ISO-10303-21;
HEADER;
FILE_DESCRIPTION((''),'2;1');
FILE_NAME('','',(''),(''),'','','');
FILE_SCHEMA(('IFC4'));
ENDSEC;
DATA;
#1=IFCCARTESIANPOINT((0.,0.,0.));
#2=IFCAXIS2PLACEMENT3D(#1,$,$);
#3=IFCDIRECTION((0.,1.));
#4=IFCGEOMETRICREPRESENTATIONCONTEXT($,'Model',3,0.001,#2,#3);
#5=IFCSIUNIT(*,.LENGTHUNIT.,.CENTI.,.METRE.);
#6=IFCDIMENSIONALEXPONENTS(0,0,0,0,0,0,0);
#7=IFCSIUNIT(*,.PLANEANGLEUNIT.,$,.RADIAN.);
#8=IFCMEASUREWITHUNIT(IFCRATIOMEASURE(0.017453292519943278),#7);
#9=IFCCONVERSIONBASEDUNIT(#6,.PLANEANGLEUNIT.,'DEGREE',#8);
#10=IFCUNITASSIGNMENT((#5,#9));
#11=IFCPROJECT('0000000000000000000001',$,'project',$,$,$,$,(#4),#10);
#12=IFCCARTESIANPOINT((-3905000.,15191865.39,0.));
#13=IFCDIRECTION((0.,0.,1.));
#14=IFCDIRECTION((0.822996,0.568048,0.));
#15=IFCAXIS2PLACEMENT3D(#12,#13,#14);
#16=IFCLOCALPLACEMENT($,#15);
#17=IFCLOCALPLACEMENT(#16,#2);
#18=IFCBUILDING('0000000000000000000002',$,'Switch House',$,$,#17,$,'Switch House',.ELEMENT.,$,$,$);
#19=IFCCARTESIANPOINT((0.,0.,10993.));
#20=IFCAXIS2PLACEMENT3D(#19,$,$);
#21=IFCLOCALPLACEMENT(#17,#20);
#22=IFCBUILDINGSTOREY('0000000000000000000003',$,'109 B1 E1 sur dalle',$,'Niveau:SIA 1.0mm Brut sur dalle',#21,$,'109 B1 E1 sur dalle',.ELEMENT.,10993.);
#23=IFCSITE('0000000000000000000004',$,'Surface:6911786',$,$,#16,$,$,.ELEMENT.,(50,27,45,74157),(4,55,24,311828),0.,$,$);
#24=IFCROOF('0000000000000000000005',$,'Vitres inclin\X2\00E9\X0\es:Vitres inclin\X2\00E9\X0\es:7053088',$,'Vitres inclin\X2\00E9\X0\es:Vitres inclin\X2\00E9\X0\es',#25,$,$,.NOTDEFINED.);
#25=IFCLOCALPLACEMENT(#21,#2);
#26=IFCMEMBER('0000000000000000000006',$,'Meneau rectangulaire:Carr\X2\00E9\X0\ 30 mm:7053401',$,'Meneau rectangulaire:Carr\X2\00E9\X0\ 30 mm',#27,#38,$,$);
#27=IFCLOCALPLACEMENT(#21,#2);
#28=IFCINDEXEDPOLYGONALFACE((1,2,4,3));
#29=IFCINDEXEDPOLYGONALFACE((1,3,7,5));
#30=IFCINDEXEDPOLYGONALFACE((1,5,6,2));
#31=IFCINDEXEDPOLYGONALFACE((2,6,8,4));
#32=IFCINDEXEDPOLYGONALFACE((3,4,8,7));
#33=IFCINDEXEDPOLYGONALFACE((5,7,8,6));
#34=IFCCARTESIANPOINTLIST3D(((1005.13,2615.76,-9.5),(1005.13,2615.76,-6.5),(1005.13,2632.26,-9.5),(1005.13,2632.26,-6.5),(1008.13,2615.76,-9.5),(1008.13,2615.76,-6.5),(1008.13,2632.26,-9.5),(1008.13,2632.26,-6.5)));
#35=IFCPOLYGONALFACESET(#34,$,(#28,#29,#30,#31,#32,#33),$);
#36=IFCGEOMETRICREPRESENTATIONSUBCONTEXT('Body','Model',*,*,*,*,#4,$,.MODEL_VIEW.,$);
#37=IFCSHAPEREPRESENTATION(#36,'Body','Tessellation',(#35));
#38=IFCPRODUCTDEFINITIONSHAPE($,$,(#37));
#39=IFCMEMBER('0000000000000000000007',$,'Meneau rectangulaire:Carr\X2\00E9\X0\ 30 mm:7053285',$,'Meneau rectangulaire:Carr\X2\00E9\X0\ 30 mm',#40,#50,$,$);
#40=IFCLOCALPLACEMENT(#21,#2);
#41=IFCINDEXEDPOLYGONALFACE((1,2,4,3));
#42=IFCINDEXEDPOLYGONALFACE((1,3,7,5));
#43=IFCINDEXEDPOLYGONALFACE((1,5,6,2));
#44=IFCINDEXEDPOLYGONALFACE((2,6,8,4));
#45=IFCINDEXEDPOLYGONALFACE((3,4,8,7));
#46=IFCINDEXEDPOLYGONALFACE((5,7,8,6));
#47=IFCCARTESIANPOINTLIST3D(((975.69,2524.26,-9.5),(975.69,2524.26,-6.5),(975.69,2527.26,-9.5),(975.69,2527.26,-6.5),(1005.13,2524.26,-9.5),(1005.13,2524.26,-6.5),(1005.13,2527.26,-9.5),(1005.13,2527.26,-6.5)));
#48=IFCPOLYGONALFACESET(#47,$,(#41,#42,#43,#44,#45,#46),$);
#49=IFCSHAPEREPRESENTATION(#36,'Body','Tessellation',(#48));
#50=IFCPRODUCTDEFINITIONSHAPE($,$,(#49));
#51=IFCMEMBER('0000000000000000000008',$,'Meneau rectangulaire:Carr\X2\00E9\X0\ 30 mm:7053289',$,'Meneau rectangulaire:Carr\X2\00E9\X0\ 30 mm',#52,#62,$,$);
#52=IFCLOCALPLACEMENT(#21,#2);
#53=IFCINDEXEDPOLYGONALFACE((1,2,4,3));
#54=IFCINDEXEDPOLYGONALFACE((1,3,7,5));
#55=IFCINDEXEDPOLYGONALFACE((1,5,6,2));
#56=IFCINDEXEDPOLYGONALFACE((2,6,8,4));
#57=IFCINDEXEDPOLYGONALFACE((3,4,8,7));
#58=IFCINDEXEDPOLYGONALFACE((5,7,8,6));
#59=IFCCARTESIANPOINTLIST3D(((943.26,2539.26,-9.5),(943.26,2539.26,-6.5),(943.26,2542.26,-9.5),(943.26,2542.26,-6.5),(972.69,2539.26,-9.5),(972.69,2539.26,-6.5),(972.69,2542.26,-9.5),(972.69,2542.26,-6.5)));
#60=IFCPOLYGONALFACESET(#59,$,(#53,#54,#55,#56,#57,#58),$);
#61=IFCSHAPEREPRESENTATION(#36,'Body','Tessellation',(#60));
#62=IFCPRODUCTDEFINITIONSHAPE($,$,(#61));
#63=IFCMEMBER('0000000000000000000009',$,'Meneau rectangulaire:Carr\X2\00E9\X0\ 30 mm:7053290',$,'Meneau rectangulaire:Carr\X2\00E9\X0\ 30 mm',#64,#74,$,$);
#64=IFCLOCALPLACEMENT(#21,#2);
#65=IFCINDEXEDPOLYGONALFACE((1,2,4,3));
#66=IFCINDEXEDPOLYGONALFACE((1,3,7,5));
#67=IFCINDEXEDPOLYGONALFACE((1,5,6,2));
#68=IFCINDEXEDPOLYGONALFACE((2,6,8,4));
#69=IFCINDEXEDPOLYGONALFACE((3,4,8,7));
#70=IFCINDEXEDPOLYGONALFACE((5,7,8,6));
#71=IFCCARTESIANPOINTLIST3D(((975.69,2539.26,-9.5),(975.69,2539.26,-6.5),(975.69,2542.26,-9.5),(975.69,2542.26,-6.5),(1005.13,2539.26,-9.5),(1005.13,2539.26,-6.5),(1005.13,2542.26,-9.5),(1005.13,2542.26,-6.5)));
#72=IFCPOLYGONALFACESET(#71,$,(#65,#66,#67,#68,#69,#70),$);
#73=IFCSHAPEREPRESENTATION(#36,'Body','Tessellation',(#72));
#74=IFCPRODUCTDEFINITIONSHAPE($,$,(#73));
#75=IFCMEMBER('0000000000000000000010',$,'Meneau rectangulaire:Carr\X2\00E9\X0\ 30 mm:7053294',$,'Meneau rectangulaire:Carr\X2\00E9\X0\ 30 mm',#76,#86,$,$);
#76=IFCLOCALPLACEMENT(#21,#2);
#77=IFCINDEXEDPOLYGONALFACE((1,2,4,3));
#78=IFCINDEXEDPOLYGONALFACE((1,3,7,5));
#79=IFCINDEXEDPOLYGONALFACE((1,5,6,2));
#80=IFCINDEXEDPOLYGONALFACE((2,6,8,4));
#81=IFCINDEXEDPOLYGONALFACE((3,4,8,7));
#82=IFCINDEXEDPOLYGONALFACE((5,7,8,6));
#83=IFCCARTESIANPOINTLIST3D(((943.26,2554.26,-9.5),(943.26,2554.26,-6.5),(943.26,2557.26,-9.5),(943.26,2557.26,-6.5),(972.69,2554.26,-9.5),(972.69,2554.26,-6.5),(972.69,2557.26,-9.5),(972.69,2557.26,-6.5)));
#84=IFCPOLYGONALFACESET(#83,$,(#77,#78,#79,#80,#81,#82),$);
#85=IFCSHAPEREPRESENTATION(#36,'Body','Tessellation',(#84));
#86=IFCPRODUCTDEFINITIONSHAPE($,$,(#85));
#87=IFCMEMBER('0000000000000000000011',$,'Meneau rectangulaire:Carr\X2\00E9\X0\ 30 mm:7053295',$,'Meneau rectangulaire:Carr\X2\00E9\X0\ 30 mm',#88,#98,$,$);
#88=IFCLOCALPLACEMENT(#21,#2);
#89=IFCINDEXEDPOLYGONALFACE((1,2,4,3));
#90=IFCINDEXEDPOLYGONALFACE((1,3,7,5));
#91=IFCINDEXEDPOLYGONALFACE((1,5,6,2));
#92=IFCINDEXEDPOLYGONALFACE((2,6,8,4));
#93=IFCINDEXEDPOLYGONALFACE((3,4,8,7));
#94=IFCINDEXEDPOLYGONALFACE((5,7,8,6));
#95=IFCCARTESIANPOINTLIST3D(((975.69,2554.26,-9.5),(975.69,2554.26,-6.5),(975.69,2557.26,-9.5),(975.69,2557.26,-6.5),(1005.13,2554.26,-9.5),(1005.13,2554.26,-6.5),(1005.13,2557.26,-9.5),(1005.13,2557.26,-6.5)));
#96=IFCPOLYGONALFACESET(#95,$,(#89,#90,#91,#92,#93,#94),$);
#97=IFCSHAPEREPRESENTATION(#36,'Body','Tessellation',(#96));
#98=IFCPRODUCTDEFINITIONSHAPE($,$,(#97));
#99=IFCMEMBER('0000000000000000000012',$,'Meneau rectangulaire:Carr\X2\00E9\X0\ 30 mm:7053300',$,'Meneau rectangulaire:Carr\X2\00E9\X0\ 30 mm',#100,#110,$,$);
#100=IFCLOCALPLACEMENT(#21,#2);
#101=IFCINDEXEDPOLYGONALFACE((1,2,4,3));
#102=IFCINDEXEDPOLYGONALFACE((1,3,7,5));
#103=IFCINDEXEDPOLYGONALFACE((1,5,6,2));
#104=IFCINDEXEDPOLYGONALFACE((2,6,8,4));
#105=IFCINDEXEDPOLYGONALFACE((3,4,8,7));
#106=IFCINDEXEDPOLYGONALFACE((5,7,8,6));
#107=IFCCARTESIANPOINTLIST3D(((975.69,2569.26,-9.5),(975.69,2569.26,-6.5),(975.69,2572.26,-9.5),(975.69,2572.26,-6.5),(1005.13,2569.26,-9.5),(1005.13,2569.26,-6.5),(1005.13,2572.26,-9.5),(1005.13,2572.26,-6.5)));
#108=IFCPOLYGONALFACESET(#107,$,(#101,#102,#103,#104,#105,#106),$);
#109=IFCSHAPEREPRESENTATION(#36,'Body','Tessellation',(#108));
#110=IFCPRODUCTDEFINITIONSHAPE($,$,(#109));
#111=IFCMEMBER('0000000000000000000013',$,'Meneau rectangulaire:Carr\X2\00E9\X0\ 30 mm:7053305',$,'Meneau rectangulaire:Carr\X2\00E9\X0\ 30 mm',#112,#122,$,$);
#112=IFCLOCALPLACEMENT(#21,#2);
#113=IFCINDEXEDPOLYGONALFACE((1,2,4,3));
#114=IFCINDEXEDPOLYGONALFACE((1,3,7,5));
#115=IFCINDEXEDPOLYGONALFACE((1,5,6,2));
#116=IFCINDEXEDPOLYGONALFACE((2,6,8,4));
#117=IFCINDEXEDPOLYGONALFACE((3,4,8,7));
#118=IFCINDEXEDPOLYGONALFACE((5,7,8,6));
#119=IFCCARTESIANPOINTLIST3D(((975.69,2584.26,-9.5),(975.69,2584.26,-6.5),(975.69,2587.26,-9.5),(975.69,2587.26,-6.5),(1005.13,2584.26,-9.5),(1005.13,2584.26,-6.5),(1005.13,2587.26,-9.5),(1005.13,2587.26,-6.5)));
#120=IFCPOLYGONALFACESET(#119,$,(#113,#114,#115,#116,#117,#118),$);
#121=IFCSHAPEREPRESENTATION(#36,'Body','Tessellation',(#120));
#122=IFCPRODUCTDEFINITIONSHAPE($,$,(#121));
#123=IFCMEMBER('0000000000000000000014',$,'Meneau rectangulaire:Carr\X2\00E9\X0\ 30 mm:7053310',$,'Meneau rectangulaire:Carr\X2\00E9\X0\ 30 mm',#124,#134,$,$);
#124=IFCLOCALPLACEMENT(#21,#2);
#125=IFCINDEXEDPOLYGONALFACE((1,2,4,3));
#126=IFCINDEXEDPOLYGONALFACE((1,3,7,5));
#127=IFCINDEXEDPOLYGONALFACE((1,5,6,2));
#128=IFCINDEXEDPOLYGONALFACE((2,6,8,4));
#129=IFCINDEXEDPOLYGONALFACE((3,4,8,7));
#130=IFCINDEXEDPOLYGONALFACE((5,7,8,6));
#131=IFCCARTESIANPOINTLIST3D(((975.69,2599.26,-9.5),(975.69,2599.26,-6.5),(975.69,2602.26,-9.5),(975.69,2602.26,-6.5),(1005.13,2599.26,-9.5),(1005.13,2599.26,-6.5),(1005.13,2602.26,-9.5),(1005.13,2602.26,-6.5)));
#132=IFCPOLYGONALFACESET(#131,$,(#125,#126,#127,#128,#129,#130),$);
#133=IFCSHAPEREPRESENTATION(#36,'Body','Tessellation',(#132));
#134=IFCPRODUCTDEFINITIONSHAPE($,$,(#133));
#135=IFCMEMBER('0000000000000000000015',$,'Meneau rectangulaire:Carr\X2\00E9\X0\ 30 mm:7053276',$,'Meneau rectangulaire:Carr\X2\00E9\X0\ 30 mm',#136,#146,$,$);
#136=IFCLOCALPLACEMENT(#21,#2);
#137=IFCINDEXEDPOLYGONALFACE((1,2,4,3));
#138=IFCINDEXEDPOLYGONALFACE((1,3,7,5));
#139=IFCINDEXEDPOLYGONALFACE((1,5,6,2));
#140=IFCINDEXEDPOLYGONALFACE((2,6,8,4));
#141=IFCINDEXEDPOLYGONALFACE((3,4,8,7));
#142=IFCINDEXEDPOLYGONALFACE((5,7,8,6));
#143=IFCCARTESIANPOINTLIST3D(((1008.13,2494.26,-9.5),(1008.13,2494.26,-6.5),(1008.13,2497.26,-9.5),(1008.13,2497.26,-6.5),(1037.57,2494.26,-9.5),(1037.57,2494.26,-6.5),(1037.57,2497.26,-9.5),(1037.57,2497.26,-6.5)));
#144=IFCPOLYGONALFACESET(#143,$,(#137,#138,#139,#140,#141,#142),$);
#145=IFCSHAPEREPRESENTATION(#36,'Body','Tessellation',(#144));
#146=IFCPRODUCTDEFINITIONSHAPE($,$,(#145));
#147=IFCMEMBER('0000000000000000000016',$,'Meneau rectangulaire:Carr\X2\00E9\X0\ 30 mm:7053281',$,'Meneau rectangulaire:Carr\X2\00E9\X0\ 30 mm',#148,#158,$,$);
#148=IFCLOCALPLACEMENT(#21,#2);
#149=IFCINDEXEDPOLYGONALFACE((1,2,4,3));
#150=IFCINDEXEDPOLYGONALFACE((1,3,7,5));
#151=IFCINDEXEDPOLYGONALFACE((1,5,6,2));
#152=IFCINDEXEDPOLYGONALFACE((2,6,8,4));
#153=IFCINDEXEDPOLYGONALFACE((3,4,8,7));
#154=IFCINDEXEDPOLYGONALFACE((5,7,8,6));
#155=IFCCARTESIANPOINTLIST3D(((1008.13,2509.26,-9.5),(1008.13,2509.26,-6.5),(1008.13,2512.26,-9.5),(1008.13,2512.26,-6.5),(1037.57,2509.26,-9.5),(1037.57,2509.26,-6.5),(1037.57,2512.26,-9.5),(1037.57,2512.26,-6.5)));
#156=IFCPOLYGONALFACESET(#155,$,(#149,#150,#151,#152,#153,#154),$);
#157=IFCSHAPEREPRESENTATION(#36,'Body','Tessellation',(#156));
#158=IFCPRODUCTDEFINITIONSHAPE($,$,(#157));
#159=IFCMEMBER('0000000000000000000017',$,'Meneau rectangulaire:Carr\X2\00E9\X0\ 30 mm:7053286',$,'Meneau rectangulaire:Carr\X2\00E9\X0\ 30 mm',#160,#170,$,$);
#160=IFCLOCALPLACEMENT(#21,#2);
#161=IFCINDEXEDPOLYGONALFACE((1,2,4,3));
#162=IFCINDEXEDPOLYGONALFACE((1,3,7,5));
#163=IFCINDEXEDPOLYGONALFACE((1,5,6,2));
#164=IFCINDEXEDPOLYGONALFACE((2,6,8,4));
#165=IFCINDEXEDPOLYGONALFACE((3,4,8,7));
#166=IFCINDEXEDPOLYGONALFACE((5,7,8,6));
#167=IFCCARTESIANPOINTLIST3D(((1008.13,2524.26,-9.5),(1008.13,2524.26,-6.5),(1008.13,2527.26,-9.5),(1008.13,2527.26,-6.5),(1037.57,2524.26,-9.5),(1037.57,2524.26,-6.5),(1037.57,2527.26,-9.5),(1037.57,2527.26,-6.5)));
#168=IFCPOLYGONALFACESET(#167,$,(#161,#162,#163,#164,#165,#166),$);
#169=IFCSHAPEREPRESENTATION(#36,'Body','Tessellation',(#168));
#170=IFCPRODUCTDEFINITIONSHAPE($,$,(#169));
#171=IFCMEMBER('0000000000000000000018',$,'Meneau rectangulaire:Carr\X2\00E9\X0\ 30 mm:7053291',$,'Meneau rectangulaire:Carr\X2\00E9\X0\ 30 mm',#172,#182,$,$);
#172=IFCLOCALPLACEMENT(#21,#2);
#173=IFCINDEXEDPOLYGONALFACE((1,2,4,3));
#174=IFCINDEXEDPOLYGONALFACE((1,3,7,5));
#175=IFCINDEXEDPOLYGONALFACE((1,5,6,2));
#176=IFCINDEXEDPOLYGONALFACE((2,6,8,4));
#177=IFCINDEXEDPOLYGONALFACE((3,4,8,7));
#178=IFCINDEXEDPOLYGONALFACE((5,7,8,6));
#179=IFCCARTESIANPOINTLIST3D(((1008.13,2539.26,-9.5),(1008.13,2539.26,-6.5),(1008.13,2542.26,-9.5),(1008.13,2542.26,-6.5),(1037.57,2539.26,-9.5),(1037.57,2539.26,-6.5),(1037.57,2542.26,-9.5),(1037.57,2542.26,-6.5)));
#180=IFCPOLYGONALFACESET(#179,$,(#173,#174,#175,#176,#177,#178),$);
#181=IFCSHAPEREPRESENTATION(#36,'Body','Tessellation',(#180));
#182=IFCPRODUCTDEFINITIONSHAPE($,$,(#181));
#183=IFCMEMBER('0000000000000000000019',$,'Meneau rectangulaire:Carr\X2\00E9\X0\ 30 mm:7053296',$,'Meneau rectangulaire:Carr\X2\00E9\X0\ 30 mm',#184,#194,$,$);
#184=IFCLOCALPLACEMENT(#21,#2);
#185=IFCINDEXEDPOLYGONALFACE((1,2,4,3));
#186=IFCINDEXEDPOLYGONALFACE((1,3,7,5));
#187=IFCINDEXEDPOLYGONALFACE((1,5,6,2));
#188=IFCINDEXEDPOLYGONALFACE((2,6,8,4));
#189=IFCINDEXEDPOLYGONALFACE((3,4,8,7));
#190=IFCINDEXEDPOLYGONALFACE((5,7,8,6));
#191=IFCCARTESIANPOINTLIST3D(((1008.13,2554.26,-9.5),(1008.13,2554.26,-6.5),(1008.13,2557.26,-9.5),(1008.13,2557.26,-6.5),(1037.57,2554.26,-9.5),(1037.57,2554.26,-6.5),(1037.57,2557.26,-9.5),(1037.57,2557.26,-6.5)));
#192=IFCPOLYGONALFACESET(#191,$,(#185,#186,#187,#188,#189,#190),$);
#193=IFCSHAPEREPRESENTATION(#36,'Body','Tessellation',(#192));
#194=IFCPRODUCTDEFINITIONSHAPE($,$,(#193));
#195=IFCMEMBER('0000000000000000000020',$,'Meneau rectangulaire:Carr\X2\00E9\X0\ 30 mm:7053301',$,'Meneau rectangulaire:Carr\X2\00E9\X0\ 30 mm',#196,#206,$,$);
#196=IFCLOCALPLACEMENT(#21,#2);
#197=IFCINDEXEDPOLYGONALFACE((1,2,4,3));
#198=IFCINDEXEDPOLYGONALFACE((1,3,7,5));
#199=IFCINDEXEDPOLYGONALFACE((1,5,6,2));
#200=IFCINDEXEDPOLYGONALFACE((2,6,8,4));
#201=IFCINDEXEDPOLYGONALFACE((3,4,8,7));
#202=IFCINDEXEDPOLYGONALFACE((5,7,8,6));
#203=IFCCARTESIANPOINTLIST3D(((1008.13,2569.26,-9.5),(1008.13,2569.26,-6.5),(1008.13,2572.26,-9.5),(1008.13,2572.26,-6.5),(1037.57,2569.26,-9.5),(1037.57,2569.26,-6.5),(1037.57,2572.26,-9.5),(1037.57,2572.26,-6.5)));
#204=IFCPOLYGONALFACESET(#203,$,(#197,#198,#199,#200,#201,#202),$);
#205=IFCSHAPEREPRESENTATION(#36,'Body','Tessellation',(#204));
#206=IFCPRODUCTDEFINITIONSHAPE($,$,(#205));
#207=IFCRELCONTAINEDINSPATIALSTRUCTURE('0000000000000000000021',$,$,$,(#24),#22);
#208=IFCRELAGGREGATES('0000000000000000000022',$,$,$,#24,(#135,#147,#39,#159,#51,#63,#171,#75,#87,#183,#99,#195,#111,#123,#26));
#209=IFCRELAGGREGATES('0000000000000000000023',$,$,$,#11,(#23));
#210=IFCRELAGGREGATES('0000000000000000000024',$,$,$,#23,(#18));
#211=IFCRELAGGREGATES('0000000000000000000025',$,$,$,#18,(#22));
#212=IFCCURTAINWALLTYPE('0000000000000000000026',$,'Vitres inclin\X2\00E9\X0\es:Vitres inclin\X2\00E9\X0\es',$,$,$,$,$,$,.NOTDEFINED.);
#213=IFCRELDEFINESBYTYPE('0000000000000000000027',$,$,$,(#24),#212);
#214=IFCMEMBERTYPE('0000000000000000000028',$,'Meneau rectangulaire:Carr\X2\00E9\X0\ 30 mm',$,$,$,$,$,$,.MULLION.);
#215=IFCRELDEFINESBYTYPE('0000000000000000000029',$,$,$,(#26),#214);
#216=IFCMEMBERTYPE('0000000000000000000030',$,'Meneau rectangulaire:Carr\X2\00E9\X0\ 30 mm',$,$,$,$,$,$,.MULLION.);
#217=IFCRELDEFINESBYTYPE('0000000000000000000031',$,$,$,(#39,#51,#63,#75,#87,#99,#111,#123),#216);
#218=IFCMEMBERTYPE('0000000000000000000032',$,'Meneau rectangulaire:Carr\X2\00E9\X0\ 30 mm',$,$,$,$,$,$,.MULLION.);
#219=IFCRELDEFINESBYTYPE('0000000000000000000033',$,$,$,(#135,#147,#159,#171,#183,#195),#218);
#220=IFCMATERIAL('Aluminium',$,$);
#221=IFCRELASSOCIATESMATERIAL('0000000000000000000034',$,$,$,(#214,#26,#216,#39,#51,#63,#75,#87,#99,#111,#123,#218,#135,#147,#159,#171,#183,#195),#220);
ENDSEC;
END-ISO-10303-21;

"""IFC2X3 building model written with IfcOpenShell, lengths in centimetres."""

from ifc_helpers import new_model, entity, si_unit, converted_unit, direction, frame, origin, origin_2d_with_axis, place, context, subcontext, project, spatial, rectangle, extrude, source, transform, mapped, material, type_object, type_shapes, element, aggregate, save


model = new_model("IFC2X3")

# Units and contexts
model_context = context("Model", 3, precision=0.001, world=origin(), true_north=direction((0.0, 1.0)))
body_context = subcontext(model_context, "Body", "Model", "MODEL_VIEW")
ifc_project = project(units=[si_unit("LENGTHUNIT", "METRE", prefix="CENTI"), converted_unit("PLANEANGLEUNIT", "DEGREE", entity("IfcRatioMeasure", 0.017453292519943278), si_unit("PLANEANGLEUNIT", "RADIAN"), dimensions=[0, 0, 0, 0, 0, 0, 0])], contexts=[model_context])

# Site, building, storey
site_placement = place(None, frame((-3905000.0, 15191865.39, 0.0), z_axis=(0.0, 0.0, 1.0), x_axis=(0.822996, 0.568048, 0.0)))
site = spatial("IfcSite", under=ifc_project, at=site_placement, Name="Surface:6911786", CompositionType="ELEMENT", RefLatitude=(50, 27, 45, 74157), RefLongitude=(4, 55, 24, 311828), RefElevation=0.0)
building_placement = place(site_placement, origin())
building = spatial("IfcBuilding", under=site, at=building_placement, Name="Switch House", LongName="Switch House", CompositionType="ELEMENT")
storey_placement = place(building_placement, frame((0.0, 0.0, 10993.0)))
storey = spatial("IfcBuildingStorey", under=building, at=storey_placement, Name="109 B1 E1 sur dalle", ObjectType="Niveau:SIA 1.0mm Brut sur dalle", LongName="109 B1 E1 sur dalle", CompositionType="ELEMENT", Elevation=10993.0)

# Roof, members
curtain_wall_type = type_object("IfcCurtainWallType", Name="Vitres inclinées:Vitres inclinées", PredefinedType="NOTDEFINED")
roof_placement = place(storey_placement, frame((0.0, 0.0, -10993.0)))
roof = element("IfcRoof", 1, at=roof_placement, inside=storey, type_object=curtain_wall_type, Name="Vitres inclinées:Vitres inclinées:7053088", ObjectType="Vitres inclinées:Vitres inclinées", ShapeType="NOTDEFINED")
ifc_material = material(Name="Aluminium")
member_type_1 = type_object("IfcMemberType", Name="Meneau rectangulaire:Carré 30 mm", PredefinedType="MULLION", material=ifc_material)
shared_shape_1 = source(origin(), body_context, "Body", "SweptSolid", [
    extrude(rectangle(XDim=3.0, YDim=3.0, at=origin_2d_with_axis()), frame((0.0, 0.0, -16.5), z_axis=(0.0, 0.0, 1.0), x_axis=(0.0, -1.0, 0.0)), (0.0, 0.0, 1.0), 16.5),
])
type_shapes(member_type_1, [shared_shape_1])
member_1_placement = place(roof_placement, frame((1006.63, 2632.26, 10985.0), z_axis=(0.0, 1.0, 0.0), x_axis=(1.0, 0.0, 0.0)))
member_1 = element("IfcMember", 2, at=member_1_placement, type_object=member_type_1, material=ifc_material, Name="Meneau rectangulaire:Carré 30 mm:7053401", ObjectType="Meneau rectangulaire:Carré 30 mm", context=body_context, shape_type="MappedRepresentation", body=[
    mapped(shared_shape_1, transform((0.0, 0.0, 0.0), scale=1.0)),
])
member_type_2 = type_object("IfcMemberType", Name="Meneau rectangulaire:Carré 30 mm", PredefinedType="MULLION", material=ifc_material)
shared_shape_2 = source(origin(), body_context, "Body", "SweptSolid", [
    extrude(rectangle(XDim=3.0, YDim=3.0, at=origin_2d_with_axis()), frame((0.0, 0.0, -29.44), z_axis=(0.0, 0.0, 1.0), x_axis=(0.0, -1.0, 0.0)), (0.0, 0.0, 1.0), 29.44),
])
type_shapes(member_type_2, [shared_shape_2])
member_2_placement = place(roof_placement, frame((975.69, 2525.76, 10985.0), z_axis=(-1.0, 0.0, 0.0), x_axis=(0.0, 1.0, 0.0)))
member_2 = element("IfcMember", 3, at=member_2_placement, type_object=member_type_2, material=ifc_material, Name="Meneau rectangulaire:Carré 30 mm:7053285", ObjectType="Meneau rectangulaire:Carré 30 mm", context=body_context, shape_type="MappedRepresentation", body=[
    mapped(shared_shape_2, transform((0.0, 0.0, 0.0), scale=1.0)),
])
member_3_placement = place(roof_placement, frame((943.26, 2540.76, 10985.0), z_axis=(-1.0, 0.0, 0.0), x_axis=(0.0, 1.0, 0.0)))
member_3 = element("IfcMember", 4, at=member_3_placement, type_object=member_type_2, material=ifc_material, Name="Meneau rectangulaire:Carré 30 mm:7053289", ObjectType="Meneau rectangulaire:Carré 30 mm", context=body_context, shape_type="MappedRepresentation", body=[
    mapped(shared_shape_2, transform((0.0, 0.0, 0.0), scale=1.0)),
])
member_4_placement = place(roof_placement, frame((975.69, 2540.76, 10985.0), z_axis=(-1.0, 0.0, 0.0), x_axis=(0.0, 1.0, 0.0)))
member_4 = element("IfcMember", 5, at=member_4_placement, type_object=member_type_2, material=ifc_material, Name="Meneau rectangulaire:Carré 30 mm:7053290", ObjectType="Meneau rectangulaire:Carré 30 mm", context=body_context, shape_type="MappedRepresentation", body=[
    mapped(shared_shape_2, transform((0.0, 0.0, 0.0), scale=1.0)),
])
member_5_placement = place(roof_placement, frame((943.26, 2555.76, 10985.0), z_axis=(-1.0, 0.0, 0.0), x_axis=(0.0, 1.0, 0.0)))
member_5 = element("IfcMember", 6, at=member_5_placement, type_object=member_type_2, material=ifc_material, Name="Meneau rectangulaire:Carré 30 mm:7053294", ObjectType="Meneau rectangulaire:Carré 30 mm", context=body_context, shape_type="MappedRepresentation", body=[
    mapped(shared_shape_2, transform((0.0, 0.0, 0.0), scale=1.0)),
])
member_6_placement = place(roof_placement, frame((975.69, 2555.76, 10985.0), z_axis=(-1.0, 0.0, 0.0), x_axis=(0.0, 1.0, 0.0)))
member_6 = element("IfcMember", 7, at=member_6_placement, type_object=member_type_2, material=ifc_material, Name="Meneau rectangulaire:Carré 30 mm:7053295", ObjectType="Meneau rectangulaire:Carré 30 mm", context=body_context, shape_type="MappedRepresentation", body=[
    mapped(shared_shape_2, transform((0.0, 0.0, 0.0), scale=1.0)),
])
member_7_placement = place(roof_placement, frame((975.69, 2570.76, 10985.0), z_axis=(-1.0, 0.0, 0.0), x_axis=(0.0, 1.0, 0.0)))
member_7 = element("IfcMember", 8, at=member_7_placement, type_object=member_type_2, material=ifc_material, Name="Meneau rectangulaire:Carré 30 mm:7053300", ObjectType="Meneau rectangulaire:Carré 30 mm", context=body_context, shape_type="MappedRepresentation", body=[
    mapped(shared_shape_2, transform((0.0, 0.0, 0.0), scale=1.0)),
])
member_8_placement = place(roof_placement, frame((975.69, 2585.76, 10985.0), z_axis=(-1.0, 0.0, 0.0), x_axis=(0.0, 1.0, 0.0)))
member_8 = element("IfcMember", 9, at=member_8_placement, type_object=member_type_2, material=ifc_material, Name="Meneau rectangulaire:Carré 30 mm:7053305", ObjectType="Meneau rectangulaire:Carré 30 mm", context=body_context, shape_type="MappedRepresentation", body=[
    mapped(shared_shape_2, transform((0.0, 0.0, 0.0), scale=1.0)),
])
member_9_placement = place(roof_placement, frame((975.69, 2600.76, 10985.0), z_axis=(-1.0, 0.0, 0.0), x_axis=(0.0, 1.0, 0.0)))
member_9 = element("IfcMember", 10, at=member_9_placement, type_object=member_type_2, material=ifc_material, Name="Meneau rectangulaire:Carré 30 mm:7053310", ObjectType="Meneau rectangulaire:Carré 30 mm", context=body_context, shape_type="MappedRepresentation", body=[
    mapped(shared_shape_2, transform((0.0, 0.0, 0.0), scale=1.0)),
])
member_type_3 = type_object("IfcMemberType", Name="Meneau rectangulaire:Carré 30 mm", PredefinedType="MULLION", material=ifc_material)
shared_shape_3 = source(origin(), body_context, "Body", "SweptSolid", [
    extrude(rectangle(XDim=3.0, YDim=3.0, at=origin_2d_with_axis()), frame((0.0, 0.0, -29.44), z_axis=(0.0, 0.0, 1.0), x_axis=(0.0, -1.0, 0.0)), (0.0, 0.0, 1.0), 29.44),
])
type_shapes(member_type_3, [shared_shape_3])
member_10_placement = place(roof_placement, frame((1008.13, 2495.76, 10985.0), z_axis=(-1.0, 0.0, 0.0), x_axis=(0.0, 1.0, 0.0)))
member_10 = element("IfcMember", 11, at=member_10_placement, type_object=member_type_3, material=ifc_material, Name="Meneau rectangulaire:Carré 30 mm:7053276", ObjectType="Meneau rectangulaire:Carré 30 mm", context=body_context, shape_type="MappedRepresentation", body=[
    mapped(shared_shape_3, transform((0.0, 0.0, 0.0), scale=1.0)),
])
member_11_placement = place(roof_placement, frame((1008.13, 2510.76, 10985.0), z_axis=(-1.0, 0.0, 0.0), x_axis=(0.0, 1.0, 0.0)))
member_11 = element("IfcMember", 12, at=member_11_placement, type_object=member_type_3, material=ifc_material, Name="Meneau rectangulaire:Carré 30 mm:7053281", ObjectType="Meneau rectangulaire:Carré 30 mm", context=body_context, shape_type="MappedRepresentation", body=[
    mapped(shared_shape_3, transform((0.0, 0.0, 0.0), scale=1.0)),
])
member_12_placement = place(roof_placement, frame((1008.13, 2525.76, 10985.0), z_axis=(-1.0, 0.0, 0.0), x_axis=(0.0, 1.0, 0.0)))
member_12 = element("IfcMember", 13, at=member_12_placement, type_object=member_type_3, material=ifc_material, Name="Meneau rectangulaire:Carré 30 mm:7053286", ObjectType="Meneau rectangulaire:Carré 30 mm", context=body_context, shape_type="MappedRepresentation", body=[
    mapped(shared_shape_3, transform((0.0, 0.0, 0.0), scale=1.0)),
])
member_13_placement = place(roof_placement, frame((1008.13, 2540.76, 10985.0), z_axis=(-1.0, 0.0, 0.0), x_axis=(0.0, 1.0, 0.0)))
member_13 = element("IfcMember", 14, at=member_13_placement, type_object=member_type_3, material=ifc_material, Name="Meneau rectangulaire:Carré 30 mm:7053291", ObjectType="Meneau rectangulaire:Carré 30 mm", context=body_context, shape_type="MappedRepresentation", body=[
    mapped(shared_shape_3, transform((0.0, 0.0, 0.0), scale=1.0)),
])
member_14_placement = place(roof_placement, frame((1008.13, 2555.76, 10985.0), z_axis=(-1.0, 0.0, 0.0), x_axis=(0.0, 1.0, 0.0)))
member_14 = element("IfcMember", 15, at=member_14_placement, type_object=member_type_3, material=ifc_material, Name="Meneau rectangulaire:Carré 30 mm:7053296", ObjectType="Meneau rectangulaire:Carré 30 mm", context=body_context, shape_type="MappedRepresentation", body=[
    mapped(shared_shape_3, transform((0.0, 0.0, 0.0), scale=1.0)),
])
member_15_placement = place(roof_placement, frame((1008.13, 2570.76, 10985.0), z_axis=(-1.0, 0.0, 0.0), x_axis=(0.0, 1.0, 0.0)))
member_15 = element("IfcMember", 16, at=member_15_placement, type_object=member_type_3, material=ifc_material, Name="Meneau rectangulaire:Carré 30 mm:7053301", ObjectType="Meneau rectangulaire:Carré 30 mm", context=body_context, shape_type="MappedRepresentation", body=[
    mapped(shared_shape_3, transform((0.0, 0.0, 0.0), scale=1.0)),
])
aggregate(roof, [member_10, member_11, member_2, member_12, member_3, member_4, member_13, member_5, member_6, member_14, member_7, member_15, member_8, member_9, member_1])

save(model, "model.ifc")
